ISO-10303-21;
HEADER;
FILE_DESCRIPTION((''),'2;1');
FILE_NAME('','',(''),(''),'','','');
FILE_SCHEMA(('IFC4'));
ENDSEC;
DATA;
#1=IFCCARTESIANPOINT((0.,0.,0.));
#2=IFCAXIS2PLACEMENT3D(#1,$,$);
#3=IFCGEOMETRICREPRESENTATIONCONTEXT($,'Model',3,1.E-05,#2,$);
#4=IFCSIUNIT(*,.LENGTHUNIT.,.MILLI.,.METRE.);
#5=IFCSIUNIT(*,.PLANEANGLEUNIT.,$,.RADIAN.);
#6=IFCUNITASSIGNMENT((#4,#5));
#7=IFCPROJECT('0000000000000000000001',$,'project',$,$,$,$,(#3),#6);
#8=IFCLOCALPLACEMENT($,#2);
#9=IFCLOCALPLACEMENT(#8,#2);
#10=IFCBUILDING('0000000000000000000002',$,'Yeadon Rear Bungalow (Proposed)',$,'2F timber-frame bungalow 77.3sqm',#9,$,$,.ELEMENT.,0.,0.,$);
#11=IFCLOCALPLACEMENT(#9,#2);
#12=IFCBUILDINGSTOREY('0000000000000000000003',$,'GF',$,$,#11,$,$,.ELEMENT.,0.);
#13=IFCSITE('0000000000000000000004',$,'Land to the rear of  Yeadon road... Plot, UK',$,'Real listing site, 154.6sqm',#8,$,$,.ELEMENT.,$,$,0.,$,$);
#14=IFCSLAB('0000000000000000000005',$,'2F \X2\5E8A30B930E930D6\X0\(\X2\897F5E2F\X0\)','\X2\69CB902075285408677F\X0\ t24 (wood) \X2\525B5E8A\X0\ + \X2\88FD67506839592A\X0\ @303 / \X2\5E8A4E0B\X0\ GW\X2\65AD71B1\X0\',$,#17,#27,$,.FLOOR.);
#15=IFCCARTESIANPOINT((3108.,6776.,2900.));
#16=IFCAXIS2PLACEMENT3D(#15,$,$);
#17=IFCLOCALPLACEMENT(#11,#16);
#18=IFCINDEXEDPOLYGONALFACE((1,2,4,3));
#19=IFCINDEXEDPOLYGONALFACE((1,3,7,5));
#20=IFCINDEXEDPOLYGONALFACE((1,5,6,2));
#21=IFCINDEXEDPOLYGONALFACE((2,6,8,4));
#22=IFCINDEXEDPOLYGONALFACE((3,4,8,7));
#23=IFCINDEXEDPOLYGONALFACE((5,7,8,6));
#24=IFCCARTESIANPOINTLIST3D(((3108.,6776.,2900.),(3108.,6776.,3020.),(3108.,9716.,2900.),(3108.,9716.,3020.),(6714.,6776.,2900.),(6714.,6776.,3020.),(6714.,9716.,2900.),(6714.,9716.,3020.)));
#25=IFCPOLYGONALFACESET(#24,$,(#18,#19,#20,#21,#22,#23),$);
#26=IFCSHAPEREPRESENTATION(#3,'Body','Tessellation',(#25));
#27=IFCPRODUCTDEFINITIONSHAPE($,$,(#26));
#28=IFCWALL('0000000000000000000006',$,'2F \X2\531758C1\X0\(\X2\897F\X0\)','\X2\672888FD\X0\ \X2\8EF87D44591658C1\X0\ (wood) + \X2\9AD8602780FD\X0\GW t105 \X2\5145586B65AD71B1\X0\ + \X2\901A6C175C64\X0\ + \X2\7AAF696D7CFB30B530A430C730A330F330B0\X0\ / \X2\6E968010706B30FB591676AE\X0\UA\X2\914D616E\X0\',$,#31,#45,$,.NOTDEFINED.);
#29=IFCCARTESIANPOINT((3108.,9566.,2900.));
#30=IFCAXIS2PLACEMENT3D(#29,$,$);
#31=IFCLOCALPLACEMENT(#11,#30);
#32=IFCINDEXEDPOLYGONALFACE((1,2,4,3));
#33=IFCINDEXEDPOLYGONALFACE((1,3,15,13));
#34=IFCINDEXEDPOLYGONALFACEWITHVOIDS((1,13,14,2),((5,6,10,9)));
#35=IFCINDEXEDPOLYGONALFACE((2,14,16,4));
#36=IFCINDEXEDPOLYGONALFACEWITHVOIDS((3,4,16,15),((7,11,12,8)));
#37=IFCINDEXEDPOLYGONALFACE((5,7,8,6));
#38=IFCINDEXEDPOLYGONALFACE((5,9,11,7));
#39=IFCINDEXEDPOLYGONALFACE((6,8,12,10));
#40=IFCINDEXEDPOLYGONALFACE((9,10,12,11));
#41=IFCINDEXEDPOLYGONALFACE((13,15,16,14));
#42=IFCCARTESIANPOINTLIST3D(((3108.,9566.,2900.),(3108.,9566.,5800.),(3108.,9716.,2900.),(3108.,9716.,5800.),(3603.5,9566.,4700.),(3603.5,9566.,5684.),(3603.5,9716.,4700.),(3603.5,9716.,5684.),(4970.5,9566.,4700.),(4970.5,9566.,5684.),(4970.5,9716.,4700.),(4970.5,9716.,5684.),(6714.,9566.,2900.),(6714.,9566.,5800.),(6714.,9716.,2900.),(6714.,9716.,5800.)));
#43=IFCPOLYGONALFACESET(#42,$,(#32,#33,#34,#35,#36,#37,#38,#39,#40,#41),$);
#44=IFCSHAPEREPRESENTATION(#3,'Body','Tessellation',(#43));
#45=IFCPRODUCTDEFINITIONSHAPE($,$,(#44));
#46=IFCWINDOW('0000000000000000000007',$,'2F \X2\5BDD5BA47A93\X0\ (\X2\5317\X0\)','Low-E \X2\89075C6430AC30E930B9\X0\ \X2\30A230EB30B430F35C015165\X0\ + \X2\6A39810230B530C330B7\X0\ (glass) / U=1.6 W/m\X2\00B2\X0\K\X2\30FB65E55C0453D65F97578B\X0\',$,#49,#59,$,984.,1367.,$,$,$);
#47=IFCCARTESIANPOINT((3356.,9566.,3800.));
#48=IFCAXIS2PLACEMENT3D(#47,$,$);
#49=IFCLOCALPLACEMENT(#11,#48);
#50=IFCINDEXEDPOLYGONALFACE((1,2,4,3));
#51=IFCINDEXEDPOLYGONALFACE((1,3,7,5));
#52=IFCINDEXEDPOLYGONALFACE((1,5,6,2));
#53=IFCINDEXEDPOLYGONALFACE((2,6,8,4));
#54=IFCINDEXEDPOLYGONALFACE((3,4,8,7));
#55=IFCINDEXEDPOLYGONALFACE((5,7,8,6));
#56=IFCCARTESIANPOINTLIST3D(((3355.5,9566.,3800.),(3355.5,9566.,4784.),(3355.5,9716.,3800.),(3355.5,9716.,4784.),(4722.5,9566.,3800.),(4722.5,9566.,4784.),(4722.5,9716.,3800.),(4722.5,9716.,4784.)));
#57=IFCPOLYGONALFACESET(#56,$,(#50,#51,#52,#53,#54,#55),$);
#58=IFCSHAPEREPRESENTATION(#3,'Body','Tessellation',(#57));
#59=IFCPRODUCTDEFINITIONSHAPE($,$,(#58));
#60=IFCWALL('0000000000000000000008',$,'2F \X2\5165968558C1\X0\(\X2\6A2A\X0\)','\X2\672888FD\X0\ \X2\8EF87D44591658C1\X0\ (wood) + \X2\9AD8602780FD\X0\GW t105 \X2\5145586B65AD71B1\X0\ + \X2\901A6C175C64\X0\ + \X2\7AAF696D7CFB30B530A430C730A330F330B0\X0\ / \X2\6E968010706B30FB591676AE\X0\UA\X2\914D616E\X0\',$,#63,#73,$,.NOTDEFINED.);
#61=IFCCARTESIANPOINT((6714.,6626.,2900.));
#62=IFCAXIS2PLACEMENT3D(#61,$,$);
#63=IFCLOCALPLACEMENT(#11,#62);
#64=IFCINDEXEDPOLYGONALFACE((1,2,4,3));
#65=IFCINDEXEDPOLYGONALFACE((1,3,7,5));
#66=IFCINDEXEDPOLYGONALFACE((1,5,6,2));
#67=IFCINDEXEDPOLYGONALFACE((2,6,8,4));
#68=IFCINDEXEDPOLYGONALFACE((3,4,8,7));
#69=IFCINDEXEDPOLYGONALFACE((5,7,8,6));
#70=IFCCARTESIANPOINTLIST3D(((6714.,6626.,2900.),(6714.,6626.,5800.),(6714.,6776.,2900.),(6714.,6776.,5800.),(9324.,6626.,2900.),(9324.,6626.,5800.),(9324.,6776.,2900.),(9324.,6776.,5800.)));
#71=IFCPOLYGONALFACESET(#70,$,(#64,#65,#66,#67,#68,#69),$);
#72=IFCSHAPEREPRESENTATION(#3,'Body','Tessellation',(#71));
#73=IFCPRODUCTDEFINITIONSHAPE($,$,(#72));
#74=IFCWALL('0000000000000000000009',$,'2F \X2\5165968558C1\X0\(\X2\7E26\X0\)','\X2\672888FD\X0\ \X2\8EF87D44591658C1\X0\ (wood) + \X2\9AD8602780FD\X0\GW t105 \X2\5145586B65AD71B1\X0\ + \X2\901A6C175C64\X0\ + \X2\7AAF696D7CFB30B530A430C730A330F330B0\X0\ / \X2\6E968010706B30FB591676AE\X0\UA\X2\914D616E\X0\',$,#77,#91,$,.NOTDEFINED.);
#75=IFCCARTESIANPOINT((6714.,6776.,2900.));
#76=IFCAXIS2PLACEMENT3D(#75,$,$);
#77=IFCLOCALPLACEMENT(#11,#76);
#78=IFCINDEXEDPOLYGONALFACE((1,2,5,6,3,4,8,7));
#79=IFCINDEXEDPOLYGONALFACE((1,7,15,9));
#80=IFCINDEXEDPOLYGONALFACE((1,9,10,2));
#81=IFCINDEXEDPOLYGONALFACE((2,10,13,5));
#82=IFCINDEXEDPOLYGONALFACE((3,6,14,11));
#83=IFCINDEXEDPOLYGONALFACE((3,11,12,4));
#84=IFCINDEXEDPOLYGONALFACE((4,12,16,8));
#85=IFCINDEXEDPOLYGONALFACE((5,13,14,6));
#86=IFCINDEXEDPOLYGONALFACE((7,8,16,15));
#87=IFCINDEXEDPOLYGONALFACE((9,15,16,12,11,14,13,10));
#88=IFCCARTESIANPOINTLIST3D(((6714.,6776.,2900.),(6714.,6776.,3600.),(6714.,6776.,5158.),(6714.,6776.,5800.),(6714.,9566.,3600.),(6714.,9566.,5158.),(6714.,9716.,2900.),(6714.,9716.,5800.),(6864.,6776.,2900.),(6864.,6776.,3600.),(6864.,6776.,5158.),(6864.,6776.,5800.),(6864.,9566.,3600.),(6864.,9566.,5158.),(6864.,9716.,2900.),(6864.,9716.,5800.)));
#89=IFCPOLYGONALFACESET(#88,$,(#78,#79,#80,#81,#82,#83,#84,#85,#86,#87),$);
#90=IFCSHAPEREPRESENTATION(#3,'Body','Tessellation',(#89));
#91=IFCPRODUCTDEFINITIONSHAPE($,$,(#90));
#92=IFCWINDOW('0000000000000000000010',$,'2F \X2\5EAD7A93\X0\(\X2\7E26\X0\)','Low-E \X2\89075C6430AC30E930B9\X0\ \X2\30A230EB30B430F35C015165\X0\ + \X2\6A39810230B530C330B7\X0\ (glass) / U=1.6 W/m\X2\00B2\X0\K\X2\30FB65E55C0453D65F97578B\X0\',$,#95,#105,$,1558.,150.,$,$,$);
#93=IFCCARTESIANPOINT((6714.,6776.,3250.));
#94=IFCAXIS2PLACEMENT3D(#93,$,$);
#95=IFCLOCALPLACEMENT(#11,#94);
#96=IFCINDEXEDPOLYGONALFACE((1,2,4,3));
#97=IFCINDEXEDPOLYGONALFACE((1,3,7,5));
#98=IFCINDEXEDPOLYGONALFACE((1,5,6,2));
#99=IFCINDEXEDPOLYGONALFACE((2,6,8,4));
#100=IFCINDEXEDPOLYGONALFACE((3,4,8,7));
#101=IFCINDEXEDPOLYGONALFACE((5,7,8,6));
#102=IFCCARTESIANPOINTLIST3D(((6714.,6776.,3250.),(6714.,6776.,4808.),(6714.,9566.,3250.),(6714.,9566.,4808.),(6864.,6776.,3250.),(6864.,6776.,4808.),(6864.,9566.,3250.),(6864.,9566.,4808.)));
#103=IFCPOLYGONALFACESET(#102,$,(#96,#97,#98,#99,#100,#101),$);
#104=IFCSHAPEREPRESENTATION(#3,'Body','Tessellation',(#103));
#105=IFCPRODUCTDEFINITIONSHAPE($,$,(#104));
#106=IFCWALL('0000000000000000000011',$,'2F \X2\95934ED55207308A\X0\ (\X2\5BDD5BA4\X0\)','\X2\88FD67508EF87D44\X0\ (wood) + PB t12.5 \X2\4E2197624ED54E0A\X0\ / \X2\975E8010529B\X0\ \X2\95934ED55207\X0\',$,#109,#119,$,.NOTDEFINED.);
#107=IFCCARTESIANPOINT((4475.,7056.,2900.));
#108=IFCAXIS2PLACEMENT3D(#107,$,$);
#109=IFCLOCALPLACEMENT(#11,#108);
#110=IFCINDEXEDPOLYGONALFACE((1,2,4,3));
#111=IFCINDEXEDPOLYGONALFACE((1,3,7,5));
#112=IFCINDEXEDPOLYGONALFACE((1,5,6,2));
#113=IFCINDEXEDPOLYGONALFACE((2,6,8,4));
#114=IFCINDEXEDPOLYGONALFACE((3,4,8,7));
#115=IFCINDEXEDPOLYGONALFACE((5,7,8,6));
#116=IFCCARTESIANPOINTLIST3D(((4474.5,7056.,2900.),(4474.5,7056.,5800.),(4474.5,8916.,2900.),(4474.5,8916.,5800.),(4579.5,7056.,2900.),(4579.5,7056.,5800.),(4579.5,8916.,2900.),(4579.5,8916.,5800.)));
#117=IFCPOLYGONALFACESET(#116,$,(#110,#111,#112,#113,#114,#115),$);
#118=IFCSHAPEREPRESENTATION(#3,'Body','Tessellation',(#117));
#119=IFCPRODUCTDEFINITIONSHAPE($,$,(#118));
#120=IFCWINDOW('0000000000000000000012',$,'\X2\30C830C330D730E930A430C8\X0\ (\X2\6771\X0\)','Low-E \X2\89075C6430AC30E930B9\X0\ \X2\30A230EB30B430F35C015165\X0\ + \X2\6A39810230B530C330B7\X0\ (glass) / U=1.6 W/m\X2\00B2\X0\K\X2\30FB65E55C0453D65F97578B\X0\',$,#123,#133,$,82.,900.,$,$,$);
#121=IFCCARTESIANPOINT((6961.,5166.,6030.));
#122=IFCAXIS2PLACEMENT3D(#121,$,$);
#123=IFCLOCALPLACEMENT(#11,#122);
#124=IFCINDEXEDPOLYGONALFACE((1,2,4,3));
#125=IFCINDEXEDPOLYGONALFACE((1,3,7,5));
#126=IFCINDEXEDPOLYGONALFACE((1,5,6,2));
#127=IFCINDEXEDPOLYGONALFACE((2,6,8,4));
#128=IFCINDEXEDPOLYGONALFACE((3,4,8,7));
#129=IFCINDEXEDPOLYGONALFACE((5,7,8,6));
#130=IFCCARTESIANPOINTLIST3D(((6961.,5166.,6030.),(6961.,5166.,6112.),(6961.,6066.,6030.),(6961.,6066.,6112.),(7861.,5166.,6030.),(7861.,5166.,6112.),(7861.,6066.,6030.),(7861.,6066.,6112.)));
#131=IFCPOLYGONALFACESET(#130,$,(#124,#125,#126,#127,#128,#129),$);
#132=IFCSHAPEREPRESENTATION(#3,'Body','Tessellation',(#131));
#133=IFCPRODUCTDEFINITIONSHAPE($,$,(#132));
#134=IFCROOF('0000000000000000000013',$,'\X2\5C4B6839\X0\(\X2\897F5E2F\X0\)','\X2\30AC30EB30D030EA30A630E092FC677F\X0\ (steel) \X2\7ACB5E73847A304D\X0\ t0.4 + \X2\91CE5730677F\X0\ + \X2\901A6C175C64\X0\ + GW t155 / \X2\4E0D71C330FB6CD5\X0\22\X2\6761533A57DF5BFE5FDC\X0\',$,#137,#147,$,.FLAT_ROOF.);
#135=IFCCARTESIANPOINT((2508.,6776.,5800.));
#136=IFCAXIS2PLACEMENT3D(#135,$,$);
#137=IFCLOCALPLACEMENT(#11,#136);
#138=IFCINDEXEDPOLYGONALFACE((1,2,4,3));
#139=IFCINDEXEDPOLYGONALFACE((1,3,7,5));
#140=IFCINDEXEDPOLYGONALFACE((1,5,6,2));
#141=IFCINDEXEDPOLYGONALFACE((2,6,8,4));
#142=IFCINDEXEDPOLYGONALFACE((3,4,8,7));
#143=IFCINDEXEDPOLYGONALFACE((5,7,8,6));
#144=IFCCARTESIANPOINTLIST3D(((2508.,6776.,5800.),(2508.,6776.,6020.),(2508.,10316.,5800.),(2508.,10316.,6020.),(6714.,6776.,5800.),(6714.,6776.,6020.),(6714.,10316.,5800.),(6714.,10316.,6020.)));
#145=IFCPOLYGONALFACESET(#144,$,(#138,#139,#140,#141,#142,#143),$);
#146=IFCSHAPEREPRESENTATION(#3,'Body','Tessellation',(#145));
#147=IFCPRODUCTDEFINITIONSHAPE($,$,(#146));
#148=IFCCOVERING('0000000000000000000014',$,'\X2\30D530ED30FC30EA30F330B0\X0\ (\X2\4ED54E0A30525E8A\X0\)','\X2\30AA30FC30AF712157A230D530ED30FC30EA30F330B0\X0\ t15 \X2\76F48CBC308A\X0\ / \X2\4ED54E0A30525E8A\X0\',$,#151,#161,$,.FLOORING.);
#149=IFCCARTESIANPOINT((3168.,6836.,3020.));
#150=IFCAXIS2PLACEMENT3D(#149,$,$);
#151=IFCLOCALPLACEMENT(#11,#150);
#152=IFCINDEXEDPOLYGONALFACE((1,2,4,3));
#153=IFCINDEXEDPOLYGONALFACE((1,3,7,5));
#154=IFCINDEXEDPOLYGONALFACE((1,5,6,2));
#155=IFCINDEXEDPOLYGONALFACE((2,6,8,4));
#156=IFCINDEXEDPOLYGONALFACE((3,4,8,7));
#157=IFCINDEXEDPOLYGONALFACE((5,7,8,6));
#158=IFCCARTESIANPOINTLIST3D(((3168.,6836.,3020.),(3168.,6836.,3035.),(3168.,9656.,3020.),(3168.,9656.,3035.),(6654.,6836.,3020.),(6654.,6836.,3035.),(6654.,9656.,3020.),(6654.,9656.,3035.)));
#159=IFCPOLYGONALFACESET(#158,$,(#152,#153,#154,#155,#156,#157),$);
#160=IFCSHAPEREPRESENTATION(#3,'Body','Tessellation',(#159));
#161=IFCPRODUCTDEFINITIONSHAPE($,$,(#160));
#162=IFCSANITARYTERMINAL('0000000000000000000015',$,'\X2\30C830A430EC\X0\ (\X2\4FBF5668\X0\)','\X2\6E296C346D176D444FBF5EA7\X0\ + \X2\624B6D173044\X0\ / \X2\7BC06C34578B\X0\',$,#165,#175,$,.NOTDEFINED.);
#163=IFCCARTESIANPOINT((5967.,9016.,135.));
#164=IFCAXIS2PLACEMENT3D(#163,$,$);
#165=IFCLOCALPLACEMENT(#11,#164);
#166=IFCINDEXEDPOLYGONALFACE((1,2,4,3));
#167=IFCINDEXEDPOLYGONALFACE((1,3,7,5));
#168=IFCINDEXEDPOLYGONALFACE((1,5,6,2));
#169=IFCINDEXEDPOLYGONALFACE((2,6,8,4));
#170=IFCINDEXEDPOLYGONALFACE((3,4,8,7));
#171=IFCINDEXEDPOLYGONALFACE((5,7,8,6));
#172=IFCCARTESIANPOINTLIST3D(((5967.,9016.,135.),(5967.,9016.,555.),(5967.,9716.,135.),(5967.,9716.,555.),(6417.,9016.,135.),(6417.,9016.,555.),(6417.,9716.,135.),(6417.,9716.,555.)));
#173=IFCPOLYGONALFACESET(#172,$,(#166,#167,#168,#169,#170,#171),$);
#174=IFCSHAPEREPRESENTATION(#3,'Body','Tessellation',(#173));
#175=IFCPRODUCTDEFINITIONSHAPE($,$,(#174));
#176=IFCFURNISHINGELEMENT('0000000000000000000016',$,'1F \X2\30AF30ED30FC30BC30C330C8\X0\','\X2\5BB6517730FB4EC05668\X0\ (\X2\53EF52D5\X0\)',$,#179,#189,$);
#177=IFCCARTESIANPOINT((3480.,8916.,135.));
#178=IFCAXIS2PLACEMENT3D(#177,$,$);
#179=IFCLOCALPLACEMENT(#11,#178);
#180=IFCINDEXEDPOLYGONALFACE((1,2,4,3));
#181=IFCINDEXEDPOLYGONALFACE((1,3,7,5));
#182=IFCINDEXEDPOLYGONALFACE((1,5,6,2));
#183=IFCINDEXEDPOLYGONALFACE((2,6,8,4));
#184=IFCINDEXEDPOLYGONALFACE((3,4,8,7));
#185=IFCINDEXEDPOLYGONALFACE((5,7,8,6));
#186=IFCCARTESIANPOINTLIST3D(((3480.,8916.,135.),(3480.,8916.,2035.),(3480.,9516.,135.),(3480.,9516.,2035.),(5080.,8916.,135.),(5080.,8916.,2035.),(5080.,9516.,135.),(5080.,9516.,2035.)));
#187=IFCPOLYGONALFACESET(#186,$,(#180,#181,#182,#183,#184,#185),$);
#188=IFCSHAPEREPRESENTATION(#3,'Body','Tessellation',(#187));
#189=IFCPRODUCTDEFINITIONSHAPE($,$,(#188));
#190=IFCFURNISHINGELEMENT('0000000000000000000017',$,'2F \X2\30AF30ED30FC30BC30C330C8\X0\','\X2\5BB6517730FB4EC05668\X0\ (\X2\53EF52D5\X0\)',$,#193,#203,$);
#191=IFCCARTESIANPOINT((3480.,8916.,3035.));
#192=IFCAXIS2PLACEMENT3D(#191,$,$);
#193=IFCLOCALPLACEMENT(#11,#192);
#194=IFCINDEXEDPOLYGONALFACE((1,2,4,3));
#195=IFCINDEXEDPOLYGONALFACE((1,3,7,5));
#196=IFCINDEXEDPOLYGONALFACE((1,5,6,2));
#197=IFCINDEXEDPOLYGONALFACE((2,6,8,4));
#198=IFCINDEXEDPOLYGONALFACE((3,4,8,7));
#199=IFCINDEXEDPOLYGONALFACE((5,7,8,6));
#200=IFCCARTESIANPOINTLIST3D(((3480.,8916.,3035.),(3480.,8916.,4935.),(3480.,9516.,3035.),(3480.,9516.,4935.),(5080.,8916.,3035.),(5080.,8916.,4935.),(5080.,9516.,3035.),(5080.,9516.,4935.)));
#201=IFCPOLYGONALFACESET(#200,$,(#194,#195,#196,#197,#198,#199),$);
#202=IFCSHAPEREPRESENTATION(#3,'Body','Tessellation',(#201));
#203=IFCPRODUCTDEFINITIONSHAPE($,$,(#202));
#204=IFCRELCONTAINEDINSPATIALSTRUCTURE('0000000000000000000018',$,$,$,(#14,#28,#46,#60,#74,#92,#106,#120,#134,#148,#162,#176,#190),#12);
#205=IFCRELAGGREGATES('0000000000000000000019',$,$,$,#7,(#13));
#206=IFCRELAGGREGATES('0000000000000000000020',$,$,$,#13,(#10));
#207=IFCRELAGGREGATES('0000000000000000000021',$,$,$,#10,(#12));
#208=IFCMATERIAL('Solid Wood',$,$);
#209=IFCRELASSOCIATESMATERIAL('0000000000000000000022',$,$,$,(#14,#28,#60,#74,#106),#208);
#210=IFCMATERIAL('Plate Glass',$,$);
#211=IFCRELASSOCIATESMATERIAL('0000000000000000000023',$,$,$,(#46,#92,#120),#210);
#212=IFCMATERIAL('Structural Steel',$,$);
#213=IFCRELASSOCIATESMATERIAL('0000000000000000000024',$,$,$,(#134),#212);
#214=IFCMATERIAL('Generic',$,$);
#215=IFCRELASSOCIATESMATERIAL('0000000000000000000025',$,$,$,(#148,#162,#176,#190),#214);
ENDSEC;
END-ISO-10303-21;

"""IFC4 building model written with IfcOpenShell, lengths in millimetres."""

from ifc_helpers import new_model, si_unit, frame, frame_2d, origin, place, context, project, spatial, rectangle, extrude, material, element, fill, save


model = new_model("IFC4")

# Units and contexts
model_context = context("Model", 3, precision=1e-05, world=origin())
ifc_project = project(units=[si_unit("LENGTHUNIT", "METRE", prefix="MILLI"), si_unit("PLANEANGLEUNIT", "RADIAN")], contexts=[model_context])

# Site, building, storey
site_placement = place(None, origin())
site = spatial("IfcSite", under=ifc_project, at=site_placement, Name="Land to the rear of  Yeadon road... Plot, UK", ObjectType="Real listing site, 154.6sqm", CompositionType="ELEMENT", RefElevation=0.0)
building_placement = place(site_placement, origin())
building = spatial("IfcBuilding", under=site, at=building_placement, Name="Yeadon Rear Bungalow (Proposed)", ObjectType="2F timber-frame bungalow 77.3sqm", CompositionType="ELEMENT", ElevationOfRefHeight=0.0, ElevationOfTerrain=0.0)
storey_placement = place(building_placement, origin())
storey = spatial("IfcBuildingStorey", under=building, at=storey_placement, Name="GF", CompositionType="ELEMENT", Elevation=0.0)

# Slab
ifc_material_1 = material(Name="Solid Wood")
slab_placement = place(storey_placement, frame((3108.0, 6776.0, 2900.0)))
element("IfcSlab", 1, at=slab_placement, inside=storey, material=ifc_material_1, Name="2F 床スラブ(西帯)", Description="構造用合板 t24 (wood) 剛床 + 製材根太 @303 / 床下 GW断熱", PredefinedType="FLOOR", context=model_context, shape_type="SweptSolid", body=[
    extrude(rectangle(XDim=3606.0, YDim=2940.0, at=frame_2d((1803.0, 1470.0))), frame((3108.0, 6776.0, 2900.0)), (0.0, 0.0, 1.0), 120.0),
])

# Wall, opening, window
wall_1_placement = place(storey_placement, frame((3108.0, 9566.0, 2900.0)))
wall_1 = element("IfcWall", 2, at=wall_1_placement, inside=storey, material=ifc_material_1, Name="2F 北壁(西)", Description="木製 軸組外壁 (wood) + 高性能GW t105 充填断熱 + 通気層 + 窯業系サイディング / 準耐火・外皮UA配慮", PredefinedType="NOTDEFINED", context=model_context, shape_type="SweptSolid", body=[
    extrude(rectangle(XDim=3606.0, YDim=150.0, at=frame_2d((1803.0, 75.0))), frame((3108.0, 9566.0, 2900.0)), (0.0, 0.0, 1.0), 2900.0),
])
opening_1_placement = place(storey_placement, frame((3356.0, 9566.0, 3800.0)))
opening_1 = element("IfcOpeningElement", 3, at=opening_1_placement, cuts=wall_1, PredefinedType="NOTDEFINED", context=model_context, shape_type="SweptSolid", body=[
    extrude(rectangle(XDim=1367.0, YDim=150.0, at=frame_2d((683.0, 75.0))), frame((3356.0, 9566.0, 3800.0)), (0.0, 0.0, 1.0), 984.0),
])
ifc_material_2 = material(Name="Plate Glass")
window_1_placement = place(storey_placement, frame((3356.0, 9566.0, 3800.0)))
window_1 = element("IfcWindow", 4, at=window_1_placement, inside=storey, material=ifc_material_2, Name="2F 寝室窓 (北)", Description="Low-E 複層ガラス アルゴン封入 + 樹脂サッシ (glass) / U=1.6 W/m²K・日射取得型", OverallHeight=984.0, OverallWidth=1367.0, context=model_context, shape_type="SweptSolid", body=[
    extrude(rectangle(XDim=1367.0, YDim=150.0, at=frame_2d((683.0, 75.0))), frame((3356.0, 9566.0, 3800.0)), (0.0, 0.0, 1.0), 984.0),
])
fill(opening_1, window_1)

# Wall
wall_2_placement = place(storey_placement, frame((6714.0, 6626.0, 2900.0)))
element("IfcWall", 5, at=wall_2_placement, inside=storey, material=ifc_material_1, Name="2F 入隅壁(横)", Description="木製 軸組外壁 (wood) + 高性能GW t105 充填断熱 + 通気層 + 窯業系サイディング / 準耐火・外皮UA配慮", PredefinedType="NOTDEFINED", context=model_context, shape_type="SweptSolid", body=[
    extrude(rectangle(XDim=2610.0, YDim=150.0, at=frame_2d((1305.0, 75.0))), frame((6714.0, 6626.0, 2900.0)), (0.0, 0.0, 1.0), 2900.0),
])

# Wall, opening, window
wall_3_placement = place(storey_placement, frame((6714.0, 6776.0, 2900.0)))
wall_3 = element("IfcWall", 6, at=wall_3_placement, inside=storey, material=ifc_material_1, Name="2F 入隅壁(縦)", Description="木製 軸組外壁 (wood) + 高性能GW t105 充填断熱 + 通気層 + 窯業系サイディング / 準耐火・外皮UA配慮", PredefinedType="NOTDEFINED", context=model_context, shape_type="SweptSolid", body=[
    extrude(rectangle(XDim=150.0, YDim=2940.0, at=frame_2d((75.0, 1470.0))), frame((6714.0, 6776.0, 2900.0)), (0.0, 0.0, 1.0), 2900.0),
])
opening_2_placement = place(storey_placement, frame((6714.0, 6776.0, 3250.0)))
opening_2 = element("IfcOpeningElement", 7, at=opening_2_placement, cuts=wall_3, PredefinedType="NOTDEFINED", context=model_context, shape_type="SweptSolid", body=[
    extrude(rectangle(XDim=150.0, YDim=2790.0, at=frame_2d((75.0, 1395.0))), frame((6714.0, 6776.0, 3250.0)), (0.0, 0.0, 1.0), 1558.0),
])
window_2_placement = place(storey_placement, frame((6714.0, 6776.0, 3250.0)))
window_2 = element("IfcWindow", 8, at=window_2_placement, inside=storey, material=ifc_material_2, Name="2F 庭窓(縦)", Description="Low-E 複層ガラス アルゴン封入 + 樹脂サッシ (glass) / U=1.6 W/m²K・日射取得型", OverallHeight=1558.0, OverallWidth=150.0, context=model_context, shape_type="SweptSolid", body=[
    extrude(rectangle(XDim=150.0, YDim=2790.0, at=frame_2d((75.0, 1395.0))), frame((6714.0, 6776.0, 3250.0)), (0.0, 0.0, 1.0), 1558.0),
])
fill(opening_2, window_2)

# Wall
wall_4_placement = place(storey_placement, frame((4475.0, 7056.0, 2900.0)))
element("IfcWall", 9, at=wall_4_placement, inside=storey, material=ifc_material_1, Name="2F 間仕切り (寝室)", Description="製材軸組 (wood) + PB t12.5 両面仕上 / 非耐力 間仕切", PredefinedType="NOTDEFINED", context=model_context, shape_type="SweptSolid", body=[
    extrude(rectangle(XDim=105.0, YDim=1860.0, at=frame_2d((52.0, 930.0))), frame((4475.0, 7056.0, 2900.0)), (0.0, 0.0, 1.0), 2900.0),
])

# Window
window_3_placement = place(storey_placement, frame((6961.0, 5166.0, 6030.0)))
element("IfcWindow", 10, at=window_3_placement, inside=storey, material=ifc_material_2, Name="トップライト (東)", Description="Low-E 複層ガラス アルゴン封入 + 樹脂サッシ (glass) / U=1.6 W/m²K・日射取得型", OverallHeight=82.0, OverallWidth=900.0, context=model_context, shape_type="SweptSolid", body=[
    extrude(rectangle(XDim=900.0, YDim=900.0, at=frame_2d((450.0, 450.0))), frame((6961.0, 5166.0, 6030.0)), (0.0, 0.0, 1.0), 82.0),
])

# Roof
ifc_material_3 = material(Name="Structural Steel")
for number, where, name in (
    (11, (2508.0, 6776.0, 5800.0), "屋根(西帯)"),
):
    element("IfcRoof", number, at=place(storey_placement, frame(where)), inside=storey, material=ifc_material_3, Name=name, Description="ガルバリウム鋼板 (steel) 立平葺き t0.4 + 野地板 + 通気層 + GW t155 / 不燃・法22条区域対応", PredefinedType="FLAT_ROOF", context=model_context, shape_type="SweptSolid", body=[
        extrude(rectangle(XDim=4206.0, YDim=3540.0, at=frame_2d((2103.0, 1770.0))), frame((2508.0, 6776.0, 5800.0)), (0.0, 0.0, 1.0), 220.0),
    ])

# Covering
ifc_material_4 = material(Name="Generic")
covering_placement = place(storey_placement, frame((3168.0, 6836.0, 3020.0)))
element("IfcCovering", 12, at=covering_placement, inside=storey, material=ifc_material_4, Name="フローリング (仕上げ床)", Description="オーク無垢フローリング t15 直貼り / 仕上げ床", PredefinedType="FLOORING", context=model_context, shape_type="SweptSolid", body=[
    extrude(rectangle(XDim=3486.0, YDim=2820.0, at=frame_2d((1743.0, 1410.0))), frame((3168.0, 6836.0, 3020.0)), (0.0, 0.0, 1.0), 15.0),
])

# Sanitary terminal
sanitary_terminal_placement = place(storey_placement, frame((5967.0, 9016.0, 135.0)))
element("IfcSanitaryTerminal", 13, at=sanitary_terminal_placement, inside=storey, material=ifc_material_4, Name="トイレ (便器)", Description="温水洗浄便座 + 手洗い / 節水型", PredefinedType="NOTDEFINED", context=model_context, shape_type="SweptSolid", body=[
    extrude(rectangle(XDim=450.0, YDim=700.0, at=frame_2d((225.0, 350.0))), frame((5967.0, 9016.0, 135.0)), (0.0, 0.0, 1.0), 420.0),
])

# Furnishing elements
furnishing_1_placement = place(storey_placement, frame((3480.0, 8916.0, 135.0)))
element("IfcFurnishingElement", 14, at=furnishing_1_placement, inside=storey, material=ifc_material_4, Name="1F クローゼット", Description="家具・什器 (可動)", context=model_context, shape_type="SweptSolid", body=[
    extrude(rectangle(XDim=1600.0, YDim=600.0, at=frame_2d((800.0, 300.0))), frame((3480.0, 8916.0, 135.0)), (0.0, 0.0, 1.0), 1900.0),
])
furnishing_2_placement = place(storey_placement, frame((3480.0, 8916.0, 3035.0)))
element("IfcFurnishingElement", 15, at=furnishing_2_placement, inside=storey, material=ifc_material_4, Name="2F クローゼット", Description="家具・什器 (可動)", context=model_context, shape_type="SweptSolid", body=[
    extrude(rectangle(XDim=1600.0, YDim=600.0, at=frame_2d((800.0, 300.0))), frame((3480.0, 8916.0, 3035.0)), (0.0, 0.0, 1.0), 1900.0),
])

save(model, "model.ifc")
